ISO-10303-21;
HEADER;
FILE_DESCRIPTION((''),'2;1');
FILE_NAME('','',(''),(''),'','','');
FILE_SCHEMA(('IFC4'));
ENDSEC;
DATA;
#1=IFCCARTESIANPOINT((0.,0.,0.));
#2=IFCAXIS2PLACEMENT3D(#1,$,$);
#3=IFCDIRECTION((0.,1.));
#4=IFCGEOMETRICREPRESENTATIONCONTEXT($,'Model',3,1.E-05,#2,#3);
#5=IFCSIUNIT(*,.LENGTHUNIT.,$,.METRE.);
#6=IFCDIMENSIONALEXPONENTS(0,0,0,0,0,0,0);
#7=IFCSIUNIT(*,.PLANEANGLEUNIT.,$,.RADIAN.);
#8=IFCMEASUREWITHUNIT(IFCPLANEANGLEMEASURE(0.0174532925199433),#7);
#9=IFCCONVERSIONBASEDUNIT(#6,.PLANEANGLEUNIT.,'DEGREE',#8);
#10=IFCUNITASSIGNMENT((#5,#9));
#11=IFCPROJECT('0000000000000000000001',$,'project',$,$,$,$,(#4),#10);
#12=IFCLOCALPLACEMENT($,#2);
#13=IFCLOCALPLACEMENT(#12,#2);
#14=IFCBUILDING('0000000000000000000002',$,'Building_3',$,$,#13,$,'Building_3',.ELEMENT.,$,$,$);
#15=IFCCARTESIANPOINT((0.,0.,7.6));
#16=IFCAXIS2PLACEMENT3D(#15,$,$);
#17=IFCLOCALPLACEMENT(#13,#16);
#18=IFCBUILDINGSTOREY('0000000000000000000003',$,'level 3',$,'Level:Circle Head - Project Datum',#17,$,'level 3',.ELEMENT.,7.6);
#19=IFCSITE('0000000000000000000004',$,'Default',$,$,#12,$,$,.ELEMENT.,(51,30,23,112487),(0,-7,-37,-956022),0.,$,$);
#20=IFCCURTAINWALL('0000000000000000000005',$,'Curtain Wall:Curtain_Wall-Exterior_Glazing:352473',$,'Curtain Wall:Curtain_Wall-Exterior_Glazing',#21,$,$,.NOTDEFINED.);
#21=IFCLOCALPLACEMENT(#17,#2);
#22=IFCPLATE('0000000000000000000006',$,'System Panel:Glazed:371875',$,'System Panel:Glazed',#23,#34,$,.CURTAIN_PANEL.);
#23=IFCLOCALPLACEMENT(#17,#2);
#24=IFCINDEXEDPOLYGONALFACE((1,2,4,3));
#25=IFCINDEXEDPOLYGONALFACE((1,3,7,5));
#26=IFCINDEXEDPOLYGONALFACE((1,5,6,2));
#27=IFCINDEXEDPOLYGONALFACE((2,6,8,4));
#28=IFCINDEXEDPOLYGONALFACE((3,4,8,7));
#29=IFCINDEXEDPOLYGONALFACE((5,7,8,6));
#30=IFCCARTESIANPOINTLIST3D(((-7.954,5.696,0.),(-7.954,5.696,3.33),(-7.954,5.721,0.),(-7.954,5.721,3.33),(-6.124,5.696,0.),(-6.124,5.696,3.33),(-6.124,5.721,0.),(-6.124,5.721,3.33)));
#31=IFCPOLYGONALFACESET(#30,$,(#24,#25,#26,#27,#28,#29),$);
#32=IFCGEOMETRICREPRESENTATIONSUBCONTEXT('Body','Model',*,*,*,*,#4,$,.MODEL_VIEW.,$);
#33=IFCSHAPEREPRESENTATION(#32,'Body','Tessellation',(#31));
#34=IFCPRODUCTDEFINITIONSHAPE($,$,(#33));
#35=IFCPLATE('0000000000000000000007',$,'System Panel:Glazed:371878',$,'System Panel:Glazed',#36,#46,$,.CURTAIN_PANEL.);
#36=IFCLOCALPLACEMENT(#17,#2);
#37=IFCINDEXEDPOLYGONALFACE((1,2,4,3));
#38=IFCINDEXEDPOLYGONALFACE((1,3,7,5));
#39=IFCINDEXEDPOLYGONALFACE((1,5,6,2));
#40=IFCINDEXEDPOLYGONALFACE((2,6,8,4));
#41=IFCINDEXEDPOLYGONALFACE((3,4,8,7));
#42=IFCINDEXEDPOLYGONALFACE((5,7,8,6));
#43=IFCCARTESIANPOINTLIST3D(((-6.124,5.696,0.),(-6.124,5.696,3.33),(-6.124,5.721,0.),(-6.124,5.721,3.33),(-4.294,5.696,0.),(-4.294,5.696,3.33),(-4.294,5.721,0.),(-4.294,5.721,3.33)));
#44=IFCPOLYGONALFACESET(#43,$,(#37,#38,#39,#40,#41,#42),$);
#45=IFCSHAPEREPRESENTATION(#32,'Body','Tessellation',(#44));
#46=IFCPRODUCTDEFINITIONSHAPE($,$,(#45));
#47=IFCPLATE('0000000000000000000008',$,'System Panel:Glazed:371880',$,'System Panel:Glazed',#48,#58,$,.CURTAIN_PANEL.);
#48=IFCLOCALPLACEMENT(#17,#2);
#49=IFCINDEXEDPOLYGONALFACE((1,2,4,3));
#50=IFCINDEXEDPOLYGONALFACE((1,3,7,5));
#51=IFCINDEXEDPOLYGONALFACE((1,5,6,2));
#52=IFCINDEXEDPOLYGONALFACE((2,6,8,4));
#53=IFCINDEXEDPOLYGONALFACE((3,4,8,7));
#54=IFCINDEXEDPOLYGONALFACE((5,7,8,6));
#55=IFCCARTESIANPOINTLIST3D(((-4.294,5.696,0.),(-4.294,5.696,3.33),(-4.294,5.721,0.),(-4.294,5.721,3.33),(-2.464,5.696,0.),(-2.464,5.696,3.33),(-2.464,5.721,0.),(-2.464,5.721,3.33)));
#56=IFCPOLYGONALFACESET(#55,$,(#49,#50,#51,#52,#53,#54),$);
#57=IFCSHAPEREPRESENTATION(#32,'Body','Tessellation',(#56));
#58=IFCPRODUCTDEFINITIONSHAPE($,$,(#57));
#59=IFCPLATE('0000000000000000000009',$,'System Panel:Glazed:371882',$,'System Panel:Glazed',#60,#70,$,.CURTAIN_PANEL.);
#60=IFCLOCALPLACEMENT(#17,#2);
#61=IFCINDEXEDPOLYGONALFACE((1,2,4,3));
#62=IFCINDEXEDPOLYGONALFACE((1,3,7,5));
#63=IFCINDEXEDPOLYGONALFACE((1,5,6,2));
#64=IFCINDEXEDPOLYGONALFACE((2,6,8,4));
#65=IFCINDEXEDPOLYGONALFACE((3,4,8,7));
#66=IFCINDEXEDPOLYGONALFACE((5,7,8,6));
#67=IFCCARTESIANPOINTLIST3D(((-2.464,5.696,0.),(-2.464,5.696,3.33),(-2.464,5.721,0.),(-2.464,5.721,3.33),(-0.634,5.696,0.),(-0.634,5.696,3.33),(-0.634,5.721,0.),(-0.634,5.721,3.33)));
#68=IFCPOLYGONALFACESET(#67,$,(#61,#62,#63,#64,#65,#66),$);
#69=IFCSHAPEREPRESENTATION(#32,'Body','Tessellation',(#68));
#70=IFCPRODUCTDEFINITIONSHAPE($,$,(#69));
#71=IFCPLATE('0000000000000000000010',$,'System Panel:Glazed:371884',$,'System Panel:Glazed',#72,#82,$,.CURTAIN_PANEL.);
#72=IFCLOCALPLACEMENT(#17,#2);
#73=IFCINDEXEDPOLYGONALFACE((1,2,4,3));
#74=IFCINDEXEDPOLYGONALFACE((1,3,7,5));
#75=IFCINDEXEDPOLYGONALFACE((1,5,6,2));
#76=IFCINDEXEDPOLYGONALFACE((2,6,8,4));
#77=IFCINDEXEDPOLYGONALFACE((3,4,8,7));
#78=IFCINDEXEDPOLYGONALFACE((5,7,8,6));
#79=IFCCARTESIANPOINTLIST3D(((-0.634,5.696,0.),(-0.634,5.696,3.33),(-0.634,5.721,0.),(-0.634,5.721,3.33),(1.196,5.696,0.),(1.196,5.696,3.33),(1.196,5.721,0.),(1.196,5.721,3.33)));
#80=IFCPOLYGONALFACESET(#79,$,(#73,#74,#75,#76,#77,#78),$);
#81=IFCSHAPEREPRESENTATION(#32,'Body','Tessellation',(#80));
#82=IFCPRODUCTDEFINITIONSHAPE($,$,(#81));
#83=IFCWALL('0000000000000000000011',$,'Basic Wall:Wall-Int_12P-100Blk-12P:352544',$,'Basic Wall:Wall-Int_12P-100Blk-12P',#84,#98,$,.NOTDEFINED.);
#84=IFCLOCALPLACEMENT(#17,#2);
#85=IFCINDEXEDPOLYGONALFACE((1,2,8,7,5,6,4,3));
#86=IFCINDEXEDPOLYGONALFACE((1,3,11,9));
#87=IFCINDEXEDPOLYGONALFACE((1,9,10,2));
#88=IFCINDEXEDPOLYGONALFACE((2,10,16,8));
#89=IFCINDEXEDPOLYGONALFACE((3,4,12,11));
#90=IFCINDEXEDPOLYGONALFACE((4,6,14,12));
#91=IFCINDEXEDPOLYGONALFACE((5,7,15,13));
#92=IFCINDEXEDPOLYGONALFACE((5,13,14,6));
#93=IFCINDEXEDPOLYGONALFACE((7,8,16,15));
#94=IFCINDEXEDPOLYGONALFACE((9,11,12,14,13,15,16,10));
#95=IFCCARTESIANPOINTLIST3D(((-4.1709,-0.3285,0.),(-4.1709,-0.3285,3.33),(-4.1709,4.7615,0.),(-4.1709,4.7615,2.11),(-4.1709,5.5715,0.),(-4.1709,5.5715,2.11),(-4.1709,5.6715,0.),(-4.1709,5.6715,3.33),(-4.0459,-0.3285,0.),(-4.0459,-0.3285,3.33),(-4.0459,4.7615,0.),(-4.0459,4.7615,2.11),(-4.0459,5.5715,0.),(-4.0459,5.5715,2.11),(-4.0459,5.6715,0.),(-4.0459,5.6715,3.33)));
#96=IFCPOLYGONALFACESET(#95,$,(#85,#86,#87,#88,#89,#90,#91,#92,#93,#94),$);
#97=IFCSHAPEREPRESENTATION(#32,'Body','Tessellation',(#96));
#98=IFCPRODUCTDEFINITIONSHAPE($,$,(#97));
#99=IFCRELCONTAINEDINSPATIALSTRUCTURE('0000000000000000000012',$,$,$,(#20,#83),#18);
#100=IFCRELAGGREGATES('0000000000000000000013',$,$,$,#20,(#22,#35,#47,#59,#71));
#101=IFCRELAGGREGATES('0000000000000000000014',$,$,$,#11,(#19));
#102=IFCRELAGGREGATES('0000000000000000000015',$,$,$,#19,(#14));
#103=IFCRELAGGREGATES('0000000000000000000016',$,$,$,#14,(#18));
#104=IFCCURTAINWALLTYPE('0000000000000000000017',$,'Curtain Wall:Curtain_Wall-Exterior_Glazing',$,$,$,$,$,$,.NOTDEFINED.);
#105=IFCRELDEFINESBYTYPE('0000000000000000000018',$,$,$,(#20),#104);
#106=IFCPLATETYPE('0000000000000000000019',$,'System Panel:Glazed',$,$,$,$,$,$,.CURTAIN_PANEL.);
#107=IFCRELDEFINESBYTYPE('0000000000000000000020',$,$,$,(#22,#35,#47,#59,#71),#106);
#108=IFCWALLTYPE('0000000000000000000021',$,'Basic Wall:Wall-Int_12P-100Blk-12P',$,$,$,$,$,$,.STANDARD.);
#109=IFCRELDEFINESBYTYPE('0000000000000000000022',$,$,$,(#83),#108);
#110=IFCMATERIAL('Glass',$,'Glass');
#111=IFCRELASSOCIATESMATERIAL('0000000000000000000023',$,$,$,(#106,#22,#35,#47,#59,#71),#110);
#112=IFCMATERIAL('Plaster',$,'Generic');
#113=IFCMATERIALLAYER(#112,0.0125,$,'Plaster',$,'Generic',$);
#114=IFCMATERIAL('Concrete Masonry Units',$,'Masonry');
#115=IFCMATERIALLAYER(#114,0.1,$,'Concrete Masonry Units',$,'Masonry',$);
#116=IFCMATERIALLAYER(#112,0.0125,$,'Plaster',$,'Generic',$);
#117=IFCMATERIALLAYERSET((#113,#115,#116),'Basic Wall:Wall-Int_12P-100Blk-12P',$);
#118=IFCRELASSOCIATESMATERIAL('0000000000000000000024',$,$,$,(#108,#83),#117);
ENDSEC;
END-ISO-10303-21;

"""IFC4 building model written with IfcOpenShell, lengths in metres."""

from ifc_helpers import new_model, entity, si_unit, converted_unit, direction, frame, frame_2d, origin, origin_2d_with_axis, place, context, subcontext, project, spatial, polyline, rectangle, extrude, clip, bounded_halfspace, source, transform, mapped, material, layer, layer_set, layer_usage, type_object, type_shapes, element, aggregate, save


model = new_model("IFC4")

# Units and contexts
model_context = context("Model", 3, precision=1e-05, world=origin(), true_north=direction((0.0, 1.0)))
body_context = subcontext(model_context, "Body", "Model", "MODEL_VIEW")
ifc_project = project(units=[si_unit("LENGTHUNIT", "METRE"), converted_unit("PLANEANGLEUNIT", "DEGREE", entity("IfcPlaneAngleMeasure", 0.0174532925199433), si_unit("PLANEANGLEUNIT", "RADIAN"), dimensions=[0, 0, 0, 0, 0, 0, 0])], contexts=[model_context])

# Site, building, storey
site_placement = place(None, origin())
site = spatial("IfcSite", under=ifc_project, at=site_placement, Name="Default", CompositionType="ELEMENT", RefLatitude=(51, 30, 23, 112487), RefLongitude=(0, -7, -37, -956022), RefElevation=0.0)
building_placement = place(site_placement, origin())
building = spatial("IfcBuilding", under=site, at=building_placement, Name="Building_3", LongName="Building_3", CompositionType="ELEMENT")
storey_placement = place(building_placement, frame((0.0, 0.0, 7.6)))
storey = spatial("IfcBuildingStorey", under=building, at=storey_placement, Name="level 3", ObjectType="Level:Circle Head - Project Datum", LongName="level 3", CompositionType="ELEMENT", Elevation=7.6)

# Curtain wall, plates
curtain_wall_type = type_object("IfcCurtainWallType", Name="Curtain Wall:Curtain_Wall-Exterior_Glazing", PredefinedType="NOTDEFINED")
curtain_wall_placement = place(storey_placement, frame((0.0, 0.0, -7.6)))
curtain_wall = element("IfcCurtainWall", 1, at=curtain_wall_placement, inside=storey, type_object=curtain_wall_type, Name="Curtain Wall:Curtain_Wall-Exterior_Glazing:352473", ObjectType="Curtain Wall:Curtain_Wall-Exterior_Glazing", PredefinedType="NOTDEFINED")
ifc_material_1 = material(Name="Glass", Category="Glass")
plate_type = type_object("IfcPlateType", Name="System Panel:Glazed", PredefinedType="CURTAIN_PANEL", material=ifc_material_1)
shared_shape_1 = source(origin(), body_context, "Body", "SweptSolid", [
    extrude(rectangle(XDim=0.025, YDim=1.83, at=origin_2d_with_axis()), frame((0.915, 0.0125, 0.0), z_axis=(0.0, 0.0, 1.0), x_axis=(0.0, 1.0, 0.0)), (0.0, 0.0, 1.0), 3.33),
])
type_shapes(plate_type, [shared_shape_1])
plate_1_placement = place(curtain_wall_placement, frame((-7.954, 5.696, 7.6)))
plate_1 = element("IfcPlate", 2, at=plate_1_placement, type_object=plate_type, material=ifc_material_1, Name="System Panel:Glazed:371875", ObjectType="System Panel:Glazed", PredefinedType="CURTAIN_PANEL", context=body_context, shape_type="MappedRepresentation", body=[
    mapped(shared_shape_1, transform((0.0, 0.0, 0.0), scale=1.0)),
])
plate_2_placement = place(curtain_wall_placement, frame((-6.124, 5.696, 7.6)))
plate_2 = element("IfcPlate", 3, at=plate_2_placement, type_object=plate_type, material=ifc_material_1, Name="System Panel:Glazed:371878", ObjectType="System Panel:Glazed", PredefinedType="CURTAIN_PANEL", context=body_context, shape_type="MappedRepresentation", body=[
    mapped(shared_shape_1, transform((0.0, 0.0, 0.0), scale=1.0)),
])
plate_3_placement = place(curtain_wall_placement, frame((-4.294, 5.696, 7.6)))
plate_3 = element("IfcPlate", 4, at=plate_3_placement, type_object=plate_type, material=ifc_material_1, Name="System Panel:Glazed:371880", ObjectType="System Panel:Glazed", PredefinedType="CURTAIN_PANEL", context=body_context, shape_type="MappedRepresentation", body=[
    mapped(shared_shape_1, transform((0.0, 0.0, 0.0), scale=1.0)),
])
plate_4_placement = place(curtain_wall_placement, frame((-2.464, 5.696, 7.6)))
plate_4 = element("IfcPlate", 5, at=plate_4_placement, type_object=plate_type, material=ifc_material_1, Name="System Panel:Glazed:371882", ObjectType="System Panel:Glazed", PredefinedType="CURTAIN_PANEL", context=body_context, shape_type="MappedRepresentation", body=[
    mapped(shared_shape_1, transform((0.0, 0.0, 0.0), scale=1.0)),
])
plate_5_placement = place(curtain_wall_placement, frame((-0.634, 5.696, 7.6)))
plate_5 = element("IfcPlate", 6, at=plate_5_placement, type_object=plate_type, material=ifc_material_1, Name="System Panel:Glazed:371884", ObjectType="System Panel:Glazed", PredefinedType="CURTAIN_PANEL", context=body_context, shape_type="MappedRepresentation", body=[
    mapped(shared_shape_1, transform((0.0, 0.0, 0.0), scale=1.0)),
])
aggregate(curtain_wall, [plate_1, plate_2, plate_3, plate_4, plate_5])

# Wall, opening
ifc_material_2 = material(Name="Plaster", Category="Generic")
ifc_layer_1 = layer(ifc_material_2, 0.0125, Name="Plaster", Category="Generic")
ifc_material_3 = material(Name="Concrete Masonry Units", Category="Masonry")
ifc_layer_2 = layer(ifc_material_3, 0.1, Name="Concrete Masonry Units", Category="Masonry")
ifc_layer_3 = layer(ifc_material_2, 0.0125, Name="Plaster", Category="Generic")
ifc_layer_set_1 = layer_set([ifc_layer_1, ifc_layer_2, ifc_layer_3], Name="Basic Wall:Wall-Int_12P-100Blk-12P")
ifc_layer_usage_1 = layer_usage(ifc_layer_set_1, "AXIS2", "NEGATIVE", 0.0625)
wall_type = type_object("IfcWallType", Name="Basic Wall:Wall-Int_12P-100Blk-12P", PredefinedType="STANDARD", material=ifc_layer_set_1)
wall_placement = place(storey_placement, frame((-4.1084, 5.6715, 0.0), z_axis=(0.0, 0.0, 1.0), x_axis=(0.0, -1.0, 0.0)))
wall = element("IfcWall", 7, at=wall_placement, inside=storey, type_object=wall_type, material=ifc_layer_usage_1, Name="Basic Wall:Wall-Int_12P-100Blk-12P:352544", ObjectType="Basic Wall:Wall-Int_12P-100Blk-12P", PredefinedType="NOTDEFINED", context=body_context, shape_type="Clipping", body=[
    clip(extrude(rectangle(XDim=6.0, YDim=0.125, at=frame_2d((3.0, 0.0), x_axis=(1.0, 0.0))), origin(), (0.0, 0.0, 1.0), 3.33), bounded_halfspace(frame((0.0, -0.0625, 3.33), z_axis=(0.0, 0.0, -1.0), x_axis=(-1.0, 0.0, 0.0)), True, frame((0.0, -0.0625, 3.33)), polyline([(0.0, 0.0), (6.0, 0.0), (6.0, 0.125), (0.0, 0.125), (0.0, 0.0)]))),
])
opening_1_placement = place(wall_placement, frame((0.1, -0.0625, 0.0)))
element("IfcOpeningElement", 8, at=opening_1_placement, cuts=wall, PredefinedType="OPENING", context=body_context, shape_type="SweptSolid", body=[
    extrude(rectangle(XDim=2.11, YDim=0.81, at=frame_2d((1.055, 0.405), x_axis=(1.0, 0.0))), frame((0.0, 0.0, 0.0), z_axis=(0.0, 1.0, 0.0), x_axis=(0.0, 0.0, 1.0)), (0.0, 0.0, 1.0), 0.125),
])

save(model, "model.ifc")
